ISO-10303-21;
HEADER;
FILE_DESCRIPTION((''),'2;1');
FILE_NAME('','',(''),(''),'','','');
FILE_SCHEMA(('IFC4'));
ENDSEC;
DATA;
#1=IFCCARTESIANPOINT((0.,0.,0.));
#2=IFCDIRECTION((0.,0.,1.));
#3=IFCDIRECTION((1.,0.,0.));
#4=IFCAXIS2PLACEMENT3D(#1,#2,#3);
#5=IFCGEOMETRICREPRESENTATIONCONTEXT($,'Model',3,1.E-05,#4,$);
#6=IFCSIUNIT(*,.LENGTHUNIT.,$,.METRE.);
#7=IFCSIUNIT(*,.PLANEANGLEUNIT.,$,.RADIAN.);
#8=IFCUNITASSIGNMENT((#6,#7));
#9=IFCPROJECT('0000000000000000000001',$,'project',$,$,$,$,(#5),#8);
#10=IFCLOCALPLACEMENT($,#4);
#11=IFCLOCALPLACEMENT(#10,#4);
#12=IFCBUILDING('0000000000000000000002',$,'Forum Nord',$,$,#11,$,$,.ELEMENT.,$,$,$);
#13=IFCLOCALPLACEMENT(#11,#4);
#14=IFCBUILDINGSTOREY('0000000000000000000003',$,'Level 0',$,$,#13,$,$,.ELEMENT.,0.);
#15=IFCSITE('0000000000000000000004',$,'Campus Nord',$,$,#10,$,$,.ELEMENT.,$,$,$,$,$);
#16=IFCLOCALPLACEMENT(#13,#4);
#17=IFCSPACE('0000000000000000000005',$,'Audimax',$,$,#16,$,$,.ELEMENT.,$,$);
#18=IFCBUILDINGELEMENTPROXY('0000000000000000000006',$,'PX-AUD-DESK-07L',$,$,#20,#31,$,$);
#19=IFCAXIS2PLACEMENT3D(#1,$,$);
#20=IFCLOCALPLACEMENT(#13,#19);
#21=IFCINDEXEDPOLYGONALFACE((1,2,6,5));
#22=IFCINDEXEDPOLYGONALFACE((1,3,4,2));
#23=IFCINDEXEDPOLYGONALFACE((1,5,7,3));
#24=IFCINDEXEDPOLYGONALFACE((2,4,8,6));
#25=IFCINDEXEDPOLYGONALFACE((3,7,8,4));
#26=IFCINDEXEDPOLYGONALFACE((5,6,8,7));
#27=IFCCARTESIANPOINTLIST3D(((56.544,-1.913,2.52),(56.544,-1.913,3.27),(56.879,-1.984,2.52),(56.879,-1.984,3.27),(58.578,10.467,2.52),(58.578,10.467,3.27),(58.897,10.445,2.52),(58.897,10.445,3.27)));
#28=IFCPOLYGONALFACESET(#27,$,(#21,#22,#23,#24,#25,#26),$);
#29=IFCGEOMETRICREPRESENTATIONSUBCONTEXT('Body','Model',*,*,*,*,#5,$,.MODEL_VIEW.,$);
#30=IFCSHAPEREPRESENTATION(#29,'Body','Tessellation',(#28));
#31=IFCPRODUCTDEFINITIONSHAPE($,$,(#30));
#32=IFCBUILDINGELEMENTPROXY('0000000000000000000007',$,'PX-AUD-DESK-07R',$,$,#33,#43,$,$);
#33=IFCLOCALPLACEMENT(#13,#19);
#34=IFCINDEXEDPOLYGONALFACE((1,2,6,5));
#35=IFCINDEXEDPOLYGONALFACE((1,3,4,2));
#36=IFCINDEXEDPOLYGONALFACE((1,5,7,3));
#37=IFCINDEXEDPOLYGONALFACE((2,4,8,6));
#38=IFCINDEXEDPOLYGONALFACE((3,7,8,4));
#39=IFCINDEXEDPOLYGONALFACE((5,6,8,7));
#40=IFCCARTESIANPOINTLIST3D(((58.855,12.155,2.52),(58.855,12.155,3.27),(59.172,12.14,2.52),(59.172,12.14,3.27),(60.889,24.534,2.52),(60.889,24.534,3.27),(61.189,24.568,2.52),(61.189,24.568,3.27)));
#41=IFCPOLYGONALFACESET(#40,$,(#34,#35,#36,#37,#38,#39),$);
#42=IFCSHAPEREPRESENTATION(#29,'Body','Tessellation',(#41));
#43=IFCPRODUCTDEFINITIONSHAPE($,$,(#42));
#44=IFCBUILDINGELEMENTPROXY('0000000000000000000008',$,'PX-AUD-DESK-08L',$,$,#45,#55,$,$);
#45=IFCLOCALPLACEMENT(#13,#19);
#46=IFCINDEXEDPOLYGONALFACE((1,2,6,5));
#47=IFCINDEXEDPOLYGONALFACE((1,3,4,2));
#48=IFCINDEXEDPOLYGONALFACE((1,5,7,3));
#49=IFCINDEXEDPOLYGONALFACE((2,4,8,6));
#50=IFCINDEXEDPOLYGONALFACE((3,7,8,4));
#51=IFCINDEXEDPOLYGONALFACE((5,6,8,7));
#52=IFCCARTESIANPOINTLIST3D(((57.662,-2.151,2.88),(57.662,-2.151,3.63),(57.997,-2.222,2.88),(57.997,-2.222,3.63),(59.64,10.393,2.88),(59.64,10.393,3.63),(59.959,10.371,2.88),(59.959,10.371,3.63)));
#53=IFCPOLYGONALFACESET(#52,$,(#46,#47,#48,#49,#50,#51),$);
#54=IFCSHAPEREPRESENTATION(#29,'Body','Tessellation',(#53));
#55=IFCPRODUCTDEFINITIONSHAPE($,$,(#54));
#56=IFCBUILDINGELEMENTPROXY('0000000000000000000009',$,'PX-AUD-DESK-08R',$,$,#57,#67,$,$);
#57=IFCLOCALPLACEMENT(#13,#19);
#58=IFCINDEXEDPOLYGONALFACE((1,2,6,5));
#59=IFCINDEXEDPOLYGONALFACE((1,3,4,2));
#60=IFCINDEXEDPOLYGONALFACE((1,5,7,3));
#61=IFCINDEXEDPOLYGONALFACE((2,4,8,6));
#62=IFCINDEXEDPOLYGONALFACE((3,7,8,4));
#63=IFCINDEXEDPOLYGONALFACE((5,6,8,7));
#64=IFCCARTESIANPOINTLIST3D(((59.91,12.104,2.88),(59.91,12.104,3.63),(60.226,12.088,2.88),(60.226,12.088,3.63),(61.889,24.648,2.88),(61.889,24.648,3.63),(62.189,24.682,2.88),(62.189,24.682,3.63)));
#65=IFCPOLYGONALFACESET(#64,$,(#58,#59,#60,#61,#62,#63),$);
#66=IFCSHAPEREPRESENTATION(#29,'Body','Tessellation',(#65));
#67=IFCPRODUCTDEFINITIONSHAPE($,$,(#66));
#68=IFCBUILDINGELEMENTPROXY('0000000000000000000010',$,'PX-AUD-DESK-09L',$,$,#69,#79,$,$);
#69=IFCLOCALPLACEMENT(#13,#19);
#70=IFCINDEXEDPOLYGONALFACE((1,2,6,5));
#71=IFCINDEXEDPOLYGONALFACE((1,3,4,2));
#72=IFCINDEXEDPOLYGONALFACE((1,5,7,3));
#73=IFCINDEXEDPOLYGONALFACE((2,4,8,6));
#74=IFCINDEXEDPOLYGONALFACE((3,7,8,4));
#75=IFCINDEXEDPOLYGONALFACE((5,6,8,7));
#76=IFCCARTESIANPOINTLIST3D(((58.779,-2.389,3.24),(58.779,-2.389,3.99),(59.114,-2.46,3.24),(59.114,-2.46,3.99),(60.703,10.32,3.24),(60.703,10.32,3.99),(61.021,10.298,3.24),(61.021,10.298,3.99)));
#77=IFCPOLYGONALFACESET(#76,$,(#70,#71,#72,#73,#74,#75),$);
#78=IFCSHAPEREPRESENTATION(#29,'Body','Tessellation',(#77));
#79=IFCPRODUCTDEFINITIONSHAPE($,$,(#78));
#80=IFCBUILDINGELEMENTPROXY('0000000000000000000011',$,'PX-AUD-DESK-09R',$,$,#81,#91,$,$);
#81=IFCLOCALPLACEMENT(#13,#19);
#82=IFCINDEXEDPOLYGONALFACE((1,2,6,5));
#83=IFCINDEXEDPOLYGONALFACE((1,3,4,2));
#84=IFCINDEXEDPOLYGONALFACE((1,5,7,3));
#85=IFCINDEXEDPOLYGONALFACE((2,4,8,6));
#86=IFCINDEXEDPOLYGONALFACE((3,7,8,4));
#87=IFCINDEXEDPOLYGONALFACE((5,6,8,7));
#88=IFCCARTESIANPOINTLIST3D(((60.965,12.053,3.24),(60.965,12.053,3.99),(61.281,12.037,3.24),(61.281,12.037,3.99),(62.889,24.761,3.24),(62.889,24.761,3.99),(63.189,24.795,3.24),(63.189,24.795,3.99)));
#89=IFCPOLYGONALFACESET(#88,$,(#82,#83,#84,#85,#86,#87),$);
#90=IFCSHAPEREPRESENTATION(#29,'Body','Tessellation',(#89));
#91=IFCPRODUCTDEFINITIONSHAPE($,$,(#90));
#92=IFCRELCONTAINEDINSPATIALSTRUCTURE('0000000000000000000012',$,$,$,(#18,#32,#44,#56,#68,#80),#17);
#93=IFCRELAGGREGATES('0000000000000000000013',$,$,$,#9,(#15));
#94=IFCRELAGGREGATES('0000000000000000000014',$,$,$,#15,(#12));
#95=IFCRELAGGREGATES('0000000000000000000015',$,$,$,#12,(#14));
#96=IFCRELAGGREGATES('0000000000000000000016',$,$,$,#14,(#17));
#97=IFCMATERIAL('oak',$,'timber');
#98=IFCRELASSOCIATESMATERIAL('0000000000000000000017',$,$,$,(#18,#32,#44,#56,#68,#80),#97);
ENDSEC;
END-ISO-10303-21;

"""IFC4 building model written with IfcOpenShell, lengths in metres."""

from ifc_helpers import new_model, si_unit, frame, origin_with_axes, place, context, subcontext, project, spatial, polyline, outline, extrude, material, element, save


model = new_model("IFC4")

# Units and contexts
model_context = context("Model", 3, precision=1e-05, world=origin_with_axes())
body_context = subcontext(model_context, "Body", "Model", "MODEL_VIEW")
ifc_project = project(units=[si_unit("LENGTHUNIT", "METRE"), si_unit("PLANEANGLEUNIT", "RADIAN")], contexts=[model_context])

# Site, building, storey, space
site_placement = place(None, origin_with_axes())
site = spatial("IfcSite", under=ifc_project, at=site_placement, Name="Campus Nord", CompositionType="ELEMENT")
building_placement = place(site_placement, origin_with_axes())
building = spatial("IfcBuilding", under=site, at=building_placement, Name="Forum Nord", CompositionType="ELEMENT")
storey_placement = place(building_placement, origin_with_axes())
storey = spatial("IfcBuildingStorey", under=building, at=storey_placement, Name="Level 0", CompositionType="ELEMENT", Elevation=0.0)
space_1_placement = place(storey_placement, origin_with_axes())
space_1 = spatial("IfcSpace", under=storey, at=space_1_placement, Name="Audimax", CompositionType="ELEMENT")

# Shared definitions
ifc_material_1 = material(Name="oak", Category="timber")

# Building element proxies
proxy_1_placement = place(storey_placement, frame((0.0, 0.0, 2.52), z_axis=(0.0, 0.0, 1.0), x_axis=(1.0, 0.0, 0.0)))
element("IfcBuildingElementProxy", 1, at=proxy_1_placement, inside=space_1, material=ifc_material_1, Name="PX-AUD-DESK-07L", context=body_context, shape_type="SweptSolid", body=[
    extrude(outline(polyline([(56.544, -1.913), (56.879, -1.984), (58.897, 10.445), (58.578, 10.467), (56.544, -1.913)])), origin_with_axes(), (0.0, 0.0, 1.0), 0.75),
])
proxy_2_placement = place(storey_placement, frame((0.0, 0.0, 2.52), z_axis=(0.0, 0.0, 1.0), x_axis=(1.0, 0.0, 0.0)))
element("IfcBuildingElementProxy", 2, at=proxy_2_placement, inside=space_1, material=ifc_material_1, Name="PX-AUD-DESK-07R", context=body_context, shape_type="SweptSolid", body=[
    extrude(outline(polyline([(58.855, 12.155), (59.172, 12.14), (61.189, 24.568), (60.889, 24.534), (58.855, 12.155)])), origin_with_axes(), (0.0, 0.0, 1.0), 0.75),
])
proxy_3_placement = place(storey_placement, frame((0.0, 0.0, 2.88), z_axis=(0.0, 0.0, 1.0), x_axis=(1.0, 0.0, 0.0)))
element("IfcBuildingElementProxy", 3, at=proxy_3_placement, inside=space_1, material=ifc_material_1, Name="PX-AUD-DESK-08L", context=body_context, shape_type="SweptSolid", body=[
    extrude(outline(polyline([(57.662, -2.151), (57.997, -2.222), (59.959, 10.371), (59.64, 10.393), (57.662, -2.151)])), origin_with_axes(), (0.0, 0.0, 1.0), 0.75),
])
proxy_4_placement = place(storey_placement, frame((0.0, 0.0, 2.88), z_axis=(0.0, 0.0, 1.0), x_axis=(1.0, 0.0, 0.0)))
element("IfcBuildingElementProxy", 4, at=proxy_4_placement, inside=space_1, material=ifc_material_1, Name="PX-AUD-DESK-08R", context=body_context, shape_type="SweptSolid", body=[
    extrude(outline(polyline([(59.91, 12.104), (60.226, 12.088), (62.189, 24.682), (61.889, 24.648), (59.91, 12.104)])), origin_with_axes(), (0.0, 0.0, 1.0), 0.75),
])
proxy_5_placement = place(storey_placement, frame((0.0, 0.0, 3.24), z_axis=(0.0, 0.0, 1.0), x_axis=(1.0, 0.0, 0.0)))
element("IfcBuildingElementProxy", 5, at=proxy_5_placement, inside=space_1, material=ifc_material_1, Name="PX-AUD-DESK-09L", context=body_context, shape_type="SweptSolid", body=[
    extrude(outline(polyline([(58.779, -2.389), (59.114, -2.46), (61.021, 10.298), (60.703, 10.32), (58.779, -2.389)])), origin_with_axes(), (0.0, 0.0, 1.0), 0.75),
])
proxy_6_placement = place(storey_placement, frame((0.0, 0.0, 3.24), z_axis=(0.0, 0.0, 1.0), x_axis=(1.0, 0.0, 0.0)))
element("IfcBuildingElementProxy", 6, at=proxy_6_placement, inside=space_1, material=ifc_material_1, Name="PX-AUD-DESK-09R", context=body_context, shape_type="SweptSolid", body=[
    extrude(outline(polyline([(60.965, 12.053), (61.281, 12.037), (63.189, 24.795), (62.889, 24.761), (60.965, 12.053)])), origin_with_axes(), (0.0, 0.0, 1.0), 0.75),
])

save(model, "model.ifc")
